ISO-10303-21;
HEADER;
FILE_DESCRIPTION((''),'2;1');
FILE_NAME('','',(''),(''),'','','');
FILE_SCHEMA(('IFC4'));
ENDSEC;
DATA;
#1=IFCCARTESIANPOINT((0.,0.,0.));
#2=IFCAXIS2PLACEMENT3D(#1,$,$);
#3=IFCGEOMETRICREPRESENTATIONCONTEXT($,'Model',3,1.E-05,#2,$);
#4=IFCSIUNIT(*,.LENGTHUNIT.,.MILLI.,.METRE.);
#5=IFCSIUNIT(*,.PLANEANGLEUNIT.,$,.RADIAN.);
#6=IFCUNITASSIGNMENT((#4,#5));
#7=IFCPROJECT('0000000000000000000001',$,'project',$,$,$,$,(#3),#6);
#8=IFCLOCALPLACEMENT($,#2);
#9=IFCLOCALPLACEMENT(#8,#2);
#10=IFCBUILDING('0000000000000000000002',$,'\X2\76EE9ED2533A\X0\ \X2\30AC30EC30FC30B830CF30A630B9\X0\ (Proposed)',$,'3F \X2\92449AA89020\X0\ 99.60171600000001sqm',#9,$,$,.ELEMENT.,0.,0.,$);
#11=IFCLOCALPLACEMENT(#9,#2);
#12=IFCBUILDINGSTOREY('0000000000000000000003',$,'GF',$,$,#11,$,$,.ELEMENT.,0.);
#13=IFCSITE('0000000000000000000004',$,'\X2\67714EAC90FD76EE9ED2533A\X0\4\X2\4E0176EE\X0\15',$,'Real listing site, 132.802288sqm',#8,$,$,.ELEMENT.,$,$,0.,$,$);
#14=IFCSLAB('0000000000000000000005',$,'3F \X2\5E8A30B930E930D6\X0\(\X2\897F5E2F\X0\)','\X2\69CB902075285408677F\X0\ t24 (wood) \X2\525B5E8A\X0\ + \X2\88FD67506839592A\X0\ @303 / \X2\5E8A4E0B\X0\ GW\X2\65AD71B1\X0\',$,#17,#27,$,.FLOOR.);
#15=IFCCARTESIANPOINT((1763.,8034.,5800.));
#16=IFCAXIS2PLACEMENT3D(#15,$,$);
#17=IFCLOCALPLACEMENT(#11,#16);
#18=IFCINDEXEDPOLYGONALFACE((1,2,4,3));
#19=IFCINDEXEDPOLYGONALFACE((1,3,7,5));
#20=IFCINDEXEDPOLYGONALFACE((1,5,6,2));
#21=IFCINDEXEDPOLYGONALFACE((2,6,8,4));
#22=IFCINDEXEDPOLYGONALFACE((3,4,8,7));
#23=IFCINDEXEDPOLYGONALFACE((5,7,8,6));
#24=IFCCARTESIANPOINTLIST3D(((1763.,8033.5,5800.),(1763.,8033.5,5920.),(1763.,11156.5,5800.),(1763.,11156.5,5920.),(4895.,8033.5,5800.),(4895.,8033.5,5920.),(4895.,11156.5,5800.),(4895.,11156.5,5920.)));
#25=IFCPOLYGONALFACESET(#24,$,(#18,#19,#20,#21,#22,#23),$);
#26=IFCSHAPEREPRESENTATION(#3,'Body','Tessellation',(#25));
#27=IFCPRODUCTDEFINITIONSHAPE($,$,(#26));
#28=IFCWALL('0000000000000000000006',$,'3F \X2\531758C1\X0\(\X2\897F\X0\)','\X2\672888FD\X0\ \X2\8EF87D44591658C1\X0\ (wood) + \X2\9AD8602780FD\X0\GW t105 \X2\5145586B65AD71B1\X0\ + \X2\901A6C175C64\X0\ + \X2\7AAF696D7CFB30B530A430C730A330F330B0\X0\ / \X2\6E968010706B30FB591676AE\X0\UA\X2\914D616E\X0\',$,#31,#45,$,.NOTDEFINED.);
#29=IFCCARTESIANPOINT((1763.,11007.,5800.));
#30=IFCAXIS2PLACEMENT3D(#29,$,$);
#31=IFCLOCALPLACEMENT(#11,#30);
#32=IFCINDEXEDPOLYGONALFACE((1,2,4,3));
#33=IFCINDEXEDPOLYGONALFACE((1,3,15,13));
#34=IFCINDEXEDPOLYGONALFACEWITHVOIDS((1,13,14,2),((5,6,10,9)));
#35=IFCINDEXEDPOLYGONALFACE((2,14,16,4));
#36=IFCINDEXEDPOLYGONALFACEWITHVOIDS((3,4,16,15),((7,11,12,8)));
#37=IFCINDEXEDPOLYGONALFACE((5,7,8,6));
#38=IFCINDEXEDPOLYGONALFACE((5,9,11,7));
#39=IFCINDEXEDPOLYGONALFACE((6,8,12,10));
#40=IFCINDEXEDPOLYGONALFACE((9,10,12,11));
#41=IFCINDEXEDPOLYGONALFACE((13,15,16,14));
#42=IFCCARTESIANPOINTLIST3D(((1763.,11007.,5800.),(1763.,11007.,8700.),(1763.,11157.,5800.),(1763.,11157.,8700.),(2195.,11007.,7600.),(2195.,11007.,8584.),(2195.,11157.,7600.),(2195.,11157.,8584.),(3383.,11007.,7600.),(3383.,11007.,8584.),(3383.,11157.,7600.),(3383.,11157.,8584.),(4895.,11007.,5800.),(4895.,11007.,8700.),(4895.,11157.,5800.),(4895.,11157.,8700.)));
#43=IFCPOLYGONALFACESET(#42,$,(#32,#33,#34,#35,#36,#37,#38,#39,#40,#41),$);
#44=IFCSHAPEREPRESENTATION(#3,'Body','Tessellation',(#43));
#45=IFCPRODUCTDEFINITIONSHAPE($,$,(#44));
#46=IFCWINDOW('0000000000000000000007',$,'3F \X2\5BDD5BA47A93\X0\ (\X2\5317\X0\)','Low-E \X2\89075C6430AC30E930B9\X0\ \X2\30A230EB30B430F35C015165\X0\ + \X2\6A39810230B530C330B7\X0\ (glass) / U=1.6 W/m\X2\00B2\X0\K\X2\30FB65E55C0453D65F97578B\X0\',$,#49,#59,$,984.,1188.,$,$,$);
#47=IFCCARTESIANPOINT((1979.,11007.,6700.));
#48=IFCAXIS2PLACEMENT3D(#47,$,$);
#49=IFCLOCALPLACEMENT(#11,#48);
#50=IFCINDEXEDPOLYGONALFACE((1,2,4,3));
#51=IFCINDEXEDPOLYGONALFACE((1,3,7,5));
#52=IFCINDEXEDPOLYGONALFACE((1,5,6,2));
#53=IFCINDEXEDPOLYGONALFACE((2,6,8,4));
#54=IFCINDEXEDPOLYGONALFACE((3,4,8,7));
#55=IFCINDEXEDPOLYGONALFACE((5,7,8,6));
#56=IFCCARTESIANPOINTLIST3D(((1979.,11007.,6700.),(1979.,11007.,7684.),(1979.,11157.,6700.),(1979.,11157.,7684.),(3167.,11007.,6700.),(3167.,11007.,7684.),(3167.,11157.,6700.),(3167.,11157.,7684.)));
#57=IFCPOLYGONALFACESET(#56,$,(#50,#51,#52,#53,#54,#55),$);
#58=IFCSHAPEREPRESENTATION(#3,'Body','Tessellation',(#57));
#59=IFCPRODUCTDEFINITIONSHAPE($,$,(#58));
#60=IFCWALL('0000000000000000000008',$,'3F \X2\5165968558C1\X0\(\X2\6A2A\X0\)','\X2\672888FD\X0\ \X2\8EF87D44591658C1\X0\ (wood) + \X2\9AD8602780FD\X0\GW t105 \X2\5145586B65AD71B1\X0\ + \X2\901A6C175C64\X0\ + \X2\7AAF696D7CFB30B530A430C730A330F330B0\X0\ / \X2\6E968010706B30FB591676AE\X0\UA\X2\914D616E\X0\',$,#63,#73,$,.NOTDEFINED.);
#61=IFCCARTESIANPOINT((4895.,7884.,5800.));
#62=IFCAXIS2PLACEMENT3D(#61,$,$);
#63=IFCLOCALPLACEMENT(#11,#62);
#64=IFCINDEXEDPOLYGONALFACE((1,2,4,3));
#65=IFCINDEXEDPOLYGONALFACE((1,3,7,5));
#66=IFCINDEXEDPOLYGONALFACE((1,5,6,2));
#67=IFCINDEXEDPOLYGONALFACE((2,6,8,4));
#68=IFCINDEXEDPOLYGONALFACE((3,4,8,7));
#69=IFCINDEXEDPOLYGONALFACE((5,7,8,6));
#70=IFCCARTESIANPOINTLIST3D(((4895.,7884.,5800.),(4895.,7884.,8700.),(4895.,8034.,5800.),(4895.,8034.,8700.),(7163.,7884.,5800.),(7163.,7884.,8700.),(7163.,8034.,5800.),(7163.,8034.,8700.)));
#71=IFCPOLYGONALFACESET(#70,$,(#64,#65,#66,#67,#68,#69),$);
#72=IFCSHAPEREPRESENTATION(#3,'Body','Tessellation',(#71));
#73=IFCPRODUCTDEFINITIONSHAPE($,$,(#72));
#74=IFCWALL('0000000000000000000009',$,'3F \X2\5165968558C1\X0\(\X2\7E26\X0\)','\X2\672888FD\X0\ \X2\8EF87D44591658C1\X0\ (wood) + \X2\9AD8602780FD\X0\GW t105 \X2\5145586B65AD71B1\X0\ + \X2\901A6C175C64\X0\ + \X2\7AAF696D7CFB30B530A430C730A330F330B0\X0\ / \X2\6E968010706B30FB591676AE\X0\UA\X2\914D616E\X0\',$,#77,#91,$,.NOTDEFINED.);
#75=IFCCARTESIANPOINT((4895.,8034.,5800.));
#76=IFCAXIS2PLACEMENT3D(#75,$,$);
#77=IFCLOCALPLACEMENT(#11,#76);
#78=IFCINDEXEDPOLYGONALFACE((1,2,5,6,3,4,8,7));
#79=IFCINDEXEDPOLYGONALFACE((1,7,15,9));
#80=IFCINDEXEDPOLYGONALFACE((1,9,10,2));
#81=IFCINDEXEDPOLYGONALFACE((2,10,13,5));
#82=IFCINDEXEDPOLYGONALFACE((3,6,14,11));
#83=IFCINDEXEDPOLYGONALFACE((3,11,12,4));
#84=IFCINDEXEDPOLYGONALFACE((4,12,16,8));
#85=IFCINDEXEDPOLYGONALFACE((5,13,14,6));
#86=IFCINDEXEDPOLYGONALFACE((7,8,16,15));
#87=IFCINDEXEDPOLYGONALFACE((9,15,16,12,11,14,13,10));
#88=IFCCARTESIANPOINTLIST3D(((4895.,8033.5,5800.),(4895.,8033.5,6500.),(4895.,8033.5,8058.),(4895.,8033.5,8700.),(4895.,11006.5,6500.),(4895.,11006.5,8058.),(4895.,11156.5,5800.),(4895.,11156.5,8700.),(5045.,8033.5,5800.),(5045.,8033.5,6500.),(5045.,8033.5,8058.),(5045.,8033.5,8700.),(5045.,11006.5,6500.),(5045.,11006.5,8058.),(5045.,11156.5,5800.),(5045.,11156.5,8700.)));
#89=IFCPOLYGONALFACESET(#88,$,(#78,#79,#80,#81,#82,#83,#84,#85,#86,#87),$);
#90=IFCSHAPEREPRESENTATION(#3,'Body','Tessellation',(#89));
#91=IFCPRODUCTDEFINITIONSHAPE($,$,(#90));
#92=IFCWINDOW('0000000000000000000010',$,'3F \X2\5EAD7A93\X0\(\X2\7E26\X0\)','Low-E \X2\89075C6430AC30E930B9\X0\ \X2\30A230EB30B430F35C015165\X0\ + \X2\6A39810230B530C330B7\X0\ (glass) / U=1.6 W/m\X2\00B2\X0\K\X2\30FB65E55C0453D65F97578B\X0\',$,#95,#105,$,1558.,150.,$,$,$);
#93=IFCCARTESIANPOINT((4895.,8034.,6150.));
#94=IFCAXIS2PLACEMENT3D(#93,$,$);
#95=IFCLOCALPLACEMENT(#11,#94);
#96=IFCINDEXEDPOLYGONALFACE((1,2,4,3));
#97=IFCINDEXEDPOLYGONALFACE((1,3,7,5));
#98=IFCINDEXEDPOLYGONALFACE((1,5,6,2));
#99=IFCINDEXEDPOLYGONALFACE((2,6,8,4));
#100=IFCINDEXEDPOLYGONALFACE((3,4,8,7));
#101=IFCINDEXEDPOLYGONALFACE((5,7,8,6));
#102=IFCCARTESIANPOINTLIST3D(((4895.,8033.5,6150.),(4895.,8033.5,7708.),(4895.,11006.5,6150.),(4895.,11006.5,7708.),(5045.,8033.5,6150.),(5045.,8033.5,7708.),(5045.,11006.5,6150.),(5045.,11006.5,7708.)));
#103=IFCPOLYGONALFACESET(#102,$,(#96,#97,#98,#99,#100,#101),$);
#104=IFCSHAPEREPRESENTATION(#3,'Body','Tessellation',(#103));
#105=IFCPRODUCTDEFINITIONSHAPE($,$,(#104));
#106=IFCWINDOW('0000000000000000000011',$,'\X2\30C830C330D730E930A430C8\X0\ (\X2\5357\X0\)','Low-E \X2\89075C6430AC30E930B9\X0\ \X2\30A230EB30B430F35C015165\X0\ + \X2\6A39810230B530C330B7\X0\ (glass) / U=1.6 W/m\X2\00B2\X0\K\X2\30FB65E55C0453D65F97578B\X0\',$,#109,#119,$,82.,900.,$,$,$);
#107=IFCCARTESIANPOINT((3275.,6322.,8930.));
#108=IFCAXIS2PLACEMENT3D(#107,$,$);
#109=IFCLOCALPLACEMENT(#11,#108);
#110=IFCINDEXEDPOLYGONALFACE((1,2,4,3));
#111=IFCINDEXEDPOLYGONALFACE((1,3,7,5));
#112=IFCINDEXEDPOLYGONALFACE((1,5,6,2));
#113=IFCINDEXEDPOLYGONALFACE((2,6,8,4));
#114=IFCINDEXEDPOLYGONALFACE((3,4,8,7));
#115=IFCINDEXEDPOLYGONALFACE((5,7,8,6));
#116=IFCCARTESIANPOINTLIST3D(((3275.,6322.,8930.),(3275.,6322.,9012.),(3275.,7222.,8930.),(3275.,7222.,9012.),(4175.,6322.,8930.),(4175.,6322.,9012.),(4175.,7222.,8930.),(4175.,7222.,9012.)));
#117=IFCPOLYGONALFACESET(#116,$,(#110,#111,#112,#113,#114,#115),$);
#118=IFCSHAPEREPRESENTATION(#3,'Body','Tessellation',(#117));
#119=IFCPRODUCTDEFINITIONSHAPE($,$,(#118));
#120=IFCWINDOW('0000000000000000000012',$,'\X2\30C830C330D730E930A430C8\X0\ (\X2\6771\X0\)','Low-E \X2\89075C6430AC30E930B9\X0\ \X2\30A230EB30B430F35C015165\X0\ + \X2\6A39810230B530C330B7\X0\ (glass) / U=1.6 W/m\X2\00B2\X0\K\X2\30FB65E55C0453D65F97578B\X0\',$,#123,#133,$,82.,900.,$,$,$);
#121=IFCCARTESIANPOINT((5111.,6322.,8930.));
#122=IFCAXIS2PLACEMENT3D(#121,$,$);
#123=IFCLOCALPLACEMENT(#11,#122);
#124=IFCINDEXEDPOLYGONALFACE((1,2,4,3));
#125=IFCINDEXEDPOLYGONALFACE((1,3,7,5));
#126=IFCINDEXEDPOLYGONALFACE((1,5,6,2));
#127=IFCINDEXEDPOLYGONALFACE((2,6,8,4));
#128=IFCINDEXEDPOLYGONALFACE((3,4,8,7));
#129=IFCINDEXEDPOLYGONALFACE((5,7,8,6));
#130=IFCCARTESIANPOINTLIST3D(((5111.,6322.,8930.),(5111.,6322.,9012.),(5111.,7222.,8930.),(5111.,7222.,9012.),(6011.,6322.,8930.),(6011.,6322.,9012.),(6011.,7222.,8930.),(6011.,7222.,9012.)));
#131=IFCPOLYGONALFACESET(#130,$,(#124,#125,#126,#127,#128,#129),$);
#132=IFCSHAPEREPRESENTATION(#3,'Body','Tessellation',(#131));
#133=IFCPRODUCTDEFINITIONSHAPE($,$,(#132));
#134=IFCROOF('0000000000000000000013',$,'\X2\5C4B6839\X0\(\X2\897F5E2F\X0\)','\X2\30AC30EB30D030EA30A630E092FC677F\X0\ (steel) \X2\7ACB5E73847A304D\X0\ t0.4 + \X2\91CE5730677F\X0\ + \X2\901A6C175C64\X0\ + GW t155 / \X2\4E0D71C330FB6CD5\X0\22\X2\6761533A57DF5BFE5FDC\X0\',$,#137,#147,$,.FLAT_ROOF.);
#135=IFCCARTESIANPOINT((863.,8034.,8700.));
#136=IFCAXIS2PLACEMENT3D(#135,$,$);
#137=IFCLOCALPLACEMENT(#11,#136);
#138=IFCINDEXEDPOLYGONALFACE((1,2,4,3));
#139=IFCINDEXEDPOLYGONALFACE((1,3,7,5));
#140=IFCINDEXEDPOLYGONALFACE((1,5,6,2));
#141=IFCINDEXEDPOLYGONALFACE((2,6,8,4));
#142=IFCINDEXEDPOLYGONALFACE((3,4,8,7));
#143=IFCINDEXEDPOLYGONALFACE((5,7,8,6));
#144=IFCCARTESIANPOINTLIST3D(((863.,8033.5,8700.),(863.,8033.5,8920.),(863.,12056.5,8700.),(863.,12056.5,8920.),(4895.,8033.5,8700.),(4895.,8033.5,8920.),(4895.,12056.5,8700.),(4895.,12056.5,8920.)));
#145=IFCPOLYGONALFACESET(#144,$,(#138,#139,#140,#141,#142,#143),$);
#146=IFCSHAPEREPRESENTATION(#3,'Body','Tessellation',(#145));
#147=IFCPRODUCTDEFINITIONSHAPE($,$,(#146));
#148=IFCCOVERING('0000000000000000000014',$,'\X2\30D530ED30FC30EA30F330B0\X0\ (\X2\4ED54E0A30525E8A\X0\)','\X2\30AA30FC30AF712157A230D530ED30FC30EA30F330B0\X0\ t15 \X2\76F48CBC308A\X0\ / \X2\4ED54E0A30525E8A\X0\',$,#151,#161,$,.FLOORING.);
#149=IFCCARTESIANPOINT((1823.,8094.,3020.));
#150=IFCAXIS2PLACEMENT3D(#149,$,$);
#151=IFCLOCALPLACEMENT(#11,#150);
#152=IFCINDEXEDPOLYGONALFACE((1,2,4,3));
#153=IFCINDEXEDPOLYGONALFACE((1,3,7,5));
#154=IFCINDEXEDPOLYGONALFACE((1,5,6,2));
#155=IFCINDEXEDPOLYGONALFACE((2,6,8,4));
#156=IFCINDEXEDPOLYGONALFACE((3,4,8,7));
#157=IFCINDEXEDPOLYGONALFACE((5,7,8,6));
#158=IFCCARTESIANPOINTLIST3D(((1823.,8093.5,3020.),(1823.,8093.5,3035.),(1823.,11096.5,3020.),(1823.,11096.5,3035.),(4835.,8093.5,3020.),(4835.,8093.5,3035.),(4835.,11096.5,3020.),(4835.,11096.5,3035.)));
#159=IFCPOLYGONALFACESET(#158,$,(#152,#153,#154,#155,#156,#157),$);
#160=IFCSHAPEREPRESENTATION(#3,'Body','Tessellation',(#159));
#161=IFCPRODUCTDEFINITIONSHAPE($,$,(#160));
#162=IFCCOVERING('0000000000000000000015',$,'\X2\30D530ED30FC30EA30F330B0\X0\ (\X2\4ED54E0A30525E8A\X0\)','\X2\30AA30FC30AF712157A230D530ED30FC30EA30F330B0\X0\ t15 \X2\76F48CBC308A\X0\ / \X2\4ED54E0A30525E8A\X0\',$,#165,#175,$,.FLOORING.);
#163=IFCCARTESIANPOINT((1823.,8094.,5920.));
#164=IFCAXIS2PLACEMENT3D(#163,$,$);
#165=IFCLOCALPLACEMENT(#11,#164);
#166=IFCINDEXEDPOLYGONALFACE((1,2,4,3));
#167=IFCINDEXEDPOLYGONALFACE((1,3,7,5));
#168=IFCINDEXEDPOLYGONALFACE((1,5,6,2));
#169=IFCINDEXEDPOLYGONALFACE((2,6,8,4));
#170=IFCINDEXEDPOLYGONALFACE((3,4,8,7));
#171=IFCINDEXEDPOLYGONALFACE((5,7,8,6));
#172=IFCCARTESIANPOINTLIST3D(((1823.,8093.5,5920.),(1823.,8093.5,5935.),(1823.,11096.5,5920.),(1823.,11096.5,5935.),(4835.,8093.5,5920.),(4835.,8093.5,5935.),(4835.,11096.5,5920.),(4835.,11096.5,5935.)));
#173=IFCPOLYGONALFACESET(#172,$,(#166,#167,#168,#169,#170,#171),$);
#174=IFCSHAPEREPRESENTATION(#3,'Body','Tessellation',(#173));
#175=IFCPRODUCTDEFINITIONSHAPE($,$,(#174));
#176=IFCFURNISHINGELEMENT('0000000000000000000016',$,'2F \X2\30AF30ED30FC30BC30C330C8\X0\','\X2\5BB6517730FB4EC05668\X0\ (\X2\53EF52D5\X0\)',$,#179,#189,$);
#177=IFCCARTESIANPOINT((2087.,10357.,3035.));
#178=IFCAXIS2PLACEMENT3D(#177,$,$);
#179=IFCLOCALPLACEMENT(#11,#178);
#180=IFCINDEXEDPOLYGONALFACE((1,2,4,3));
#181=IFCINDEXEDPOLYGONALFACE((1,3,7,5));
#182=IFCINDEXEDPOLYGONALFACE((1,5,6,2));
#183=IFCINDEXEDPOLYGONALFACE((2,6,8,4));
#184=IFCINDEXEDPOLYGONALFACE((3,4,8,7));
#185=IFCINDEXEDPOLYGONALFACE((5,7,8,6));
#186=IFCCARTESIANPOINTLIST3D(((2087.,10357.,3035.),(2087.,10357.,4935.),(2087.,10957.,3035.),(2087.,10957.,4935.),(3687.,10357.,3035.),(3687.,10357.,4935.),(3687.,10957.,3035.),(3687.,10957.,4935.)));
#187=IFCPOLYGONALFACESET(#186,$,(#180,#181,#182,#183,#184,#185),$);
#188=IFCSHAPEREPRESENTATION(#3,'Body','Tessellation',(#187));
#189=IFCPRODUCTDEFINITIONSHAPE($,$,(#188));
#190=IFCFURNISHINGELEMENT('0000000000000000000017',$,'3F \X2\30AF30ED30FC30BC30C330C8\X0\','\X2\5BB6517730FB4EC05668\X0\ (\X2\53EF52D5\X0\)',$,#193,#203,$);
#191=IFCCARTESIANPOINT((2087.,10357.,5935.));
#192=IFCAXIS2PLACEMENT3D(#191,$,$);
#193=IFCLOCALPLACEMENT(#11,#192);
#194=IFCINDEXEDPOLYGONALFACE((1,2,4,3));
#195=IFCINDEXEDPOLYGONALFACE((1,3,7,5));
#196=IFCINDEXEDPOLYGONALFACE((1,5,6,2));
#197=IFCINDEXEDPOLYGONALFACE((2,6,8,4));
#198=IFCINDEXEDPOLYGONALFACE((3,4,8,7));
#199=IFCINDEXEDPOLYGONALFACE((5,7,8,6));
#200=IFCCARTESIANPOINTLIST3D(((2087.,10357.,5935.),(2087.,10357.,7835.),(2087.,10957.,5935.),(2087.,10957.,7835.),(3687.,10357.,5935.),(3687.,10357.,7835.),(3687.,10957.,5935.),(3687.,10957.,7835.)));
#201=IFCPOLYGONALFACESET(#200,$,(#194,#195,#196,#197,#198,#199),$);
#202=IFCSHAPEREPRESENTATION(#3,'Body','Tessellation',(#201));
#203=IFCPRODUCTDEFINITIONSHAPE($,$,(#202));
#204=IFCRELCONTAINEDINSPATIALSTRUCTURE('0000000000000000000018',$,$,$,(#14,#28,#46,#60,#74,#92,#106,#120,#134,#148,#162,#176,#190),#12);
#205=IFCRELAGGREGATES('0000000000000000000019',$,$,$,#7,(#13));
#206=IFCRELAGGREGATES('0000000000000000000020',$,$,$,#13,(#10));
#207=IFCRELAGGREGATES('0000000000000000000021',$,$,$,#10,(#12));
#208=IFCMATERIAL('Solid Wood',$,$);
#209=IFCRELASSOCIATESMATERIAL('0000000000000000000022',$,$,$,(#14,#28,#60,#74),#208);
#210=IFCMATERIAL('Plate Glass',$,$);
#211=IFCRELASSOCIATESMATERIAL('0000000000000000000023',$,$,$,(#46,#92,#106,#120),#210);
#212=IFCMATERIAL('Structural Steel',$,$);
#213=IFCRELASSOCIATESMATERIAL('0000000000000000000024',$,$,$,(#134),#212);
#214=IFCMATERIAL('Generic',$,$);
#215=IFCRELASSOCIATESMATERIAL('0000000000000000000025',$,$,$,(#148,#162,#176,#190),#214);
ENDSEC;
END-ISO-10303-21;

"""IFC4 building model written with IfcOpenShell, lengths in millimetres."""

from ifc_helpers import new_model, si_unit, frame, frame_2d, origin, place, context, project, spatial, rectangle, extrude, material, element, fill, save


model = new_model("IFC4")

# Units and contexts
model_context = context("Model", 3, precision=1e-05, world=origin())
ifc_project = project(units=[si_unit("LENGTHUNIT", "METRE", prefix="MILLI"), si_unit("PLANEANGLEUNIT", "RADIAN")], contexts=[model_context])

# Site, building, storey
site_placement = place(None, origin())
site = spatial("IfcSite", under=ifc_project, at=site_placement, Name="東京都目黒区4丁目15", ObjectType="Real listing site, 132.802288sqm", CompositionType="ELEMENT", RefElevation=0.0)
building_placement = place(site_placement, origin())
building = spatial("IfcBuilding", under=site, at=building_placement, Name="目黒区 ガレージハウス (Proposed)", ObjectType="3F 鉄骨造 99.60171600000001sqm", CompositionType="ELEMENT", ElevationOfRefHeight=0.0, ElevationOfTerrain=0.0)
storey_placement = place(building_placement, origin())
storey = spatial("IfcBuildingStorey", under=building, at=storey_placement, Name="GF", CompositionType="ELEMENT", Elevation=0.0)

# Slab
ifc_material_1 = material(Name="Solid Wood")
slab_placement = place(storey_placement, frame((1763.0, 8034.0, 5800.0)))
element("IfcSlab", 1, at=slab_placement, inside=storey, material=ifc_material_1, Name="3F 床スラブ(西帯)", Description="構造用合板 t24 (wood) 剛床 + 製材根太 @303 / 床下 GW断熱", PredefinedType="FLOOR", context=model_context, shape_type="SweptSolid", body=[
    extrude(rectangle(XDim=3132.0, YDim=3123.0, at=frame_2d((1566.0, 1561.0))), frame((1763.0, 8034.0, 5800.0)), (0.0, 0.0, 1.0), 120.0),
])

# Wall, opening, window
wall_1_placement = place(storey_placement, frame((1763.0, 11007.0, 5800.0)))
wall_1 = element("IfcWall", 2, at=wall_1_placement, inside=storey, material=ifc_material_1, Name="3F 北壁(西)", Description="木製 軸組外壁 (wood) + 高性能GW t105 充填断熱 + 通気層 + 窯業系サイディング / 準耐火・外皮UA配慮", PredefinedType="NOTDEFINED", context=model_context, shape_type="SweptSolid", body=[
    extrude(rectangle(XDim=3132.0, YDim=150.0, at=frame_2d((1566.0, 75.0))), frame((1763.0, 11007.0, 5800.0)), (0.0, 0.0, 1.0), 2900.0),
])
opening_1_placement = place(storey_placement, frame((1979.0, 11007.0, 6700.0)))
opening_1 = element("IfcOpeningElement", 3, at=opening_1_placement, cuts=wall_1, PredefinedType="NOTDEFINED", context=model_context, shape_type="SweptSolid", body=[
    extrude(rectangle(XDim=1188.0, YDim=150.0, at=frame_2d((594.0, 75.0))), frame((1979.0, 11007.0, 6700.0)), (0.0, 0.0, 1.0), 984.0),
])
ifc_material_2 = material(Name="Plate Glass")
window_1_placement = place(storey_placement, frame((1979.0, 11007.0, 6700.0)))
window_1 = element("IfcWindow", 4, at=window_1_placement, inside=storey, material=ifc_material_2, Name="3F 寝室窓 (北)", Description="Low-E 複層ガラス アルゴン封入 + 樹脂サッシ (glass) / U=1.6 W/m²K・日射取得型", OverallHeight=984.0, OverallWidth=1188.0, context=model_context, shape_type="SweptSolid", body=[
    extrude(rectangle(XDim=1188.0, YDim=150.0, at=frame_2d((594.0, 75.0))), frame((1979.0, 11007.0, 6700.0)), (0.0, 0.0, 1.0), 984.0),
])
fill(opening_1, window_1)

# Wall
wall_2_placement = place(storey_placement, frame((4895.0, 7884.0, 5800.0)))
element("IfcWall", 5, at=wall_2_placement, inside=storey, material=ifc_material_1, Name="3F 入隅壁(横)", Description="木製 軸組外壁 (wood) + 高性能GW t105 充填断熱 + 通気層 + 窯業系サイディング / 準耐火・外皮UA配慮", PredefinedType="NOTDEFINED", context=model_context, shape_type="SweptSolid", body=[
    extrude(rectangle(XDim=2268.0, YDim=150.0, at=frame_2d((1134.0, 75.0))), frame((4895.0, 7884.0, 5800.0)), (0.0, 0.0, 1.0), 2900.0),
])

# Wall, opening, window
wall_3_placement = place(storey_placement, frame((4895.0, 8034.0, 5800.0)))
wall_3 = element("IfcWall", 6, at=wall_3_placement, inside=storey, material=ifc_material_1, Name="3F 入隅壁(縦)", Description="木製 軸組外壁 (wood) + 高性能GW t105 充填断熱 + 通気層 + 窯業系サイディング / 準耐火・外皮UA配慮", PredefinedType="NOTDEFINED", context=model_context, shape_type="SweptSolid", body=[
    extrude(rectangle(XDim=150.0, YDim=3123.0, at=frame_2d((75.0, 1561.0))), frame((4895.0, 8034.0, 5800.0)), (0.0, 0.0, 1.0), 2900.0),
])
opening_2_placement = place(storey_placement, frame((4895.0, 8034.0, 6150.0)))
opening_2 = element("IfcOpeningElement", 7, at=opening_2_placement, cuts=wall_3, PredefinedType="NOTDEFINED", context=model_context, shape_type="SweptSolid", body=[
    extrude(rectangle(XDim=150.0, YDim=2973.0, at=frame_2d((75.0, 1486.0))), frame((4895.0, 8034.0, 6150.0)), (0.0, 0.0, 1.0), 1558.0),
])
window_2_placement = place(storey_placement, frame((4895.0, 8034.0, 6150.0)))
window_2 = element("IfcWindow", 8, at=window_2_placement, inside=storey, material=ifc_material_2, Name="3F 庭窓(縦)", Description="Low-E 複層ガラス アルゴン封入 + 樹脂サッシ (glass) / U=1.6 W/m²K・日射取得型", OverallHeight=1558.0, OverallWidth=150.0, context=model_context, shape_type="SweptSolid", body=[
    extrude(rectangle(XDim=150.0, YDim=2973.0, at=frame_2d((75.0, 1486.0))), frame((4895.0, 8034.0, 6150.0)), (0.0, 0.0, 1.0), 1558.0),
])
fill(opening_2, window_2)

# Windows
window_3_placement = place(storey_placement, frame((3275.0, 6322.0, 8930.0)))
element("IfcWindow", 9, at=window_3_placement, inside=storey, material=ifc_material_2, Name="トップライト (南)", Description="Low-E 複層ガラス アルゴン封入 + 樹脂サッシ (glass) / U=1.6 W/m²K・日射取得型", OverallHeight=82.0, OverallWidth=900.0, context=model_context, shape_type="SweptSolid", body=[
    extrude(rectangle(XDim=900.0, YDim=900.0, at=frame_2d((450.0, 450.0))), frame((3275.0, 6322.0, 8930.0)), (0.0, 0.0, 1.0), 82.0),
])
window_4_placement = place(storey_placement, frame((5111.0, 6322.0, 8930.0)))
element("IfcWindow", 10, at=window_4_placement, inside=storey, material=ifc_material_2, Name="トップライト (東)", Description="Low-E 複層ガラス アルゴン封入 + 樹脂サッシ (glass) / U=1.6 W/m²K・日射取得型", OverallHeight=82.0, OverallWidth=900.0, context=model_context, shape_type="SweptSolid", body=[
    extrude(rectangle(XDim=900.0, YDim=900.0, at=frame_2d((450.0, 450.0))), frame((5111.0, 6322.0, 8930.0)), (0.0, 0.0, 1.0), 82.0),
])

# Roof
ifc_material_3 = material(Name="Structural Steel")
for number, where, name in (
    (11, (863.0, 8034.0, 8700.0), "屋根(西帯)"),
):
    element("IfcRoof", number, at=place(storey_placement, frame(where)), inside=storey, material=ifc_material_3, Name=name, Description="ガルバリウム鋼板 (steel) 立平葺き t0.4 + 野地板 + 通気層 + GW t155 / 不燃・法22条区域対応", PredefinedType="FLAT_ROOF", context=model_context, shape_type="SweptSolid", body=[
        extrude(rectangle(XDim=4032.0, YDim=4023.0, at=frame_2d((2016.0, 2011.0))), frame((863.0, 8034.0, 8700.0)), (0.0, 0.0, 1.0), 220.0),
    ])

# Coverings
ifc_material_4 = material(Name="Generic")
covering_1_placement = place(storey_placement, frame((1823.0, 8094.0, 3020.0)))
element("IfcCovering", 12, at=covering_1_placement, inside=storey, material=ifc_material_4, Name="フローリング (仕上げ床)", Description="オーク無垢フローリング t15 直貼り / 仕上げ床", PredefinedType="FLOORING", context=model_context, shape_type="SweptSolid", body=[
    extrude(rectangle(XDim=3012.0, YDim=3003.0, at=frame_2d((1506.0, 1501.0))), frame((1823.0, 8094.0, 3020.0)), (0.0, 0.0, 1.0), 15.0),
])
covering_2_placement = place(storey_placement, frame((1823.0, 8094.0, 5920.0)))
element("IfcCovering", 13, at=covering_2_placement, inside=storey, material=ifc_material_4, Name="フローリング (仕上げ床)", Description="オーク無垢フローリング t15 直貼り / 仕上げ床", PredefinedType="FLOORING", context=model_context, shape_type="SweptSolid", body=[
    extrude(rectangle(XDim=3012.0, YDim=3003.0, at=frame_2d((1506.0, 1501.0))), frame((1823.0, 8094.0, 5920.0)), (0.0, 0.0, 1.0), 15.0),
])

# Furnishing elements
furnishing_1_placement = place(storey_placement, frame((2087.0, 10357.0, 3035.0)))
element("IfcFurnishingElement", 14, at=furnishing_1_placement, inside=storey, material=ifc_material_4, Name="2F クローゼット", Description="家具・什器 (可動)", context=model_context, shape_type="SweptSolid", body=[
    extrude(rectangle(XDim=1600.0, YDim=600.0, at=frame_2d((800.0, 300.0))), frame((2087.0, 10357.0, 3035.0)), (0.0, 0.0, 1.0), 1900.0),
])
furnishing_2_placement = place(storey_placement, frame((2087.0, 10357.0, 5935.0)))
element("IfcFurnishingElement", 15, at=furnishing_2_placement, inside=storey, material=ifc_material_4, Name="3F クローゼット", Description="家具・什器 (可動)", context=model_context, shape_type="SweptSolid", body=[
    extrude(rectangle(XDim=1600.0, YDim=600.0, at=frame_2d((800.0, 300.0))), frame((2087.0, 10357.0, 5935.0)), (0.0, 0.0, 1.0), 1900.0),
])

save(model, "model.ifc")
